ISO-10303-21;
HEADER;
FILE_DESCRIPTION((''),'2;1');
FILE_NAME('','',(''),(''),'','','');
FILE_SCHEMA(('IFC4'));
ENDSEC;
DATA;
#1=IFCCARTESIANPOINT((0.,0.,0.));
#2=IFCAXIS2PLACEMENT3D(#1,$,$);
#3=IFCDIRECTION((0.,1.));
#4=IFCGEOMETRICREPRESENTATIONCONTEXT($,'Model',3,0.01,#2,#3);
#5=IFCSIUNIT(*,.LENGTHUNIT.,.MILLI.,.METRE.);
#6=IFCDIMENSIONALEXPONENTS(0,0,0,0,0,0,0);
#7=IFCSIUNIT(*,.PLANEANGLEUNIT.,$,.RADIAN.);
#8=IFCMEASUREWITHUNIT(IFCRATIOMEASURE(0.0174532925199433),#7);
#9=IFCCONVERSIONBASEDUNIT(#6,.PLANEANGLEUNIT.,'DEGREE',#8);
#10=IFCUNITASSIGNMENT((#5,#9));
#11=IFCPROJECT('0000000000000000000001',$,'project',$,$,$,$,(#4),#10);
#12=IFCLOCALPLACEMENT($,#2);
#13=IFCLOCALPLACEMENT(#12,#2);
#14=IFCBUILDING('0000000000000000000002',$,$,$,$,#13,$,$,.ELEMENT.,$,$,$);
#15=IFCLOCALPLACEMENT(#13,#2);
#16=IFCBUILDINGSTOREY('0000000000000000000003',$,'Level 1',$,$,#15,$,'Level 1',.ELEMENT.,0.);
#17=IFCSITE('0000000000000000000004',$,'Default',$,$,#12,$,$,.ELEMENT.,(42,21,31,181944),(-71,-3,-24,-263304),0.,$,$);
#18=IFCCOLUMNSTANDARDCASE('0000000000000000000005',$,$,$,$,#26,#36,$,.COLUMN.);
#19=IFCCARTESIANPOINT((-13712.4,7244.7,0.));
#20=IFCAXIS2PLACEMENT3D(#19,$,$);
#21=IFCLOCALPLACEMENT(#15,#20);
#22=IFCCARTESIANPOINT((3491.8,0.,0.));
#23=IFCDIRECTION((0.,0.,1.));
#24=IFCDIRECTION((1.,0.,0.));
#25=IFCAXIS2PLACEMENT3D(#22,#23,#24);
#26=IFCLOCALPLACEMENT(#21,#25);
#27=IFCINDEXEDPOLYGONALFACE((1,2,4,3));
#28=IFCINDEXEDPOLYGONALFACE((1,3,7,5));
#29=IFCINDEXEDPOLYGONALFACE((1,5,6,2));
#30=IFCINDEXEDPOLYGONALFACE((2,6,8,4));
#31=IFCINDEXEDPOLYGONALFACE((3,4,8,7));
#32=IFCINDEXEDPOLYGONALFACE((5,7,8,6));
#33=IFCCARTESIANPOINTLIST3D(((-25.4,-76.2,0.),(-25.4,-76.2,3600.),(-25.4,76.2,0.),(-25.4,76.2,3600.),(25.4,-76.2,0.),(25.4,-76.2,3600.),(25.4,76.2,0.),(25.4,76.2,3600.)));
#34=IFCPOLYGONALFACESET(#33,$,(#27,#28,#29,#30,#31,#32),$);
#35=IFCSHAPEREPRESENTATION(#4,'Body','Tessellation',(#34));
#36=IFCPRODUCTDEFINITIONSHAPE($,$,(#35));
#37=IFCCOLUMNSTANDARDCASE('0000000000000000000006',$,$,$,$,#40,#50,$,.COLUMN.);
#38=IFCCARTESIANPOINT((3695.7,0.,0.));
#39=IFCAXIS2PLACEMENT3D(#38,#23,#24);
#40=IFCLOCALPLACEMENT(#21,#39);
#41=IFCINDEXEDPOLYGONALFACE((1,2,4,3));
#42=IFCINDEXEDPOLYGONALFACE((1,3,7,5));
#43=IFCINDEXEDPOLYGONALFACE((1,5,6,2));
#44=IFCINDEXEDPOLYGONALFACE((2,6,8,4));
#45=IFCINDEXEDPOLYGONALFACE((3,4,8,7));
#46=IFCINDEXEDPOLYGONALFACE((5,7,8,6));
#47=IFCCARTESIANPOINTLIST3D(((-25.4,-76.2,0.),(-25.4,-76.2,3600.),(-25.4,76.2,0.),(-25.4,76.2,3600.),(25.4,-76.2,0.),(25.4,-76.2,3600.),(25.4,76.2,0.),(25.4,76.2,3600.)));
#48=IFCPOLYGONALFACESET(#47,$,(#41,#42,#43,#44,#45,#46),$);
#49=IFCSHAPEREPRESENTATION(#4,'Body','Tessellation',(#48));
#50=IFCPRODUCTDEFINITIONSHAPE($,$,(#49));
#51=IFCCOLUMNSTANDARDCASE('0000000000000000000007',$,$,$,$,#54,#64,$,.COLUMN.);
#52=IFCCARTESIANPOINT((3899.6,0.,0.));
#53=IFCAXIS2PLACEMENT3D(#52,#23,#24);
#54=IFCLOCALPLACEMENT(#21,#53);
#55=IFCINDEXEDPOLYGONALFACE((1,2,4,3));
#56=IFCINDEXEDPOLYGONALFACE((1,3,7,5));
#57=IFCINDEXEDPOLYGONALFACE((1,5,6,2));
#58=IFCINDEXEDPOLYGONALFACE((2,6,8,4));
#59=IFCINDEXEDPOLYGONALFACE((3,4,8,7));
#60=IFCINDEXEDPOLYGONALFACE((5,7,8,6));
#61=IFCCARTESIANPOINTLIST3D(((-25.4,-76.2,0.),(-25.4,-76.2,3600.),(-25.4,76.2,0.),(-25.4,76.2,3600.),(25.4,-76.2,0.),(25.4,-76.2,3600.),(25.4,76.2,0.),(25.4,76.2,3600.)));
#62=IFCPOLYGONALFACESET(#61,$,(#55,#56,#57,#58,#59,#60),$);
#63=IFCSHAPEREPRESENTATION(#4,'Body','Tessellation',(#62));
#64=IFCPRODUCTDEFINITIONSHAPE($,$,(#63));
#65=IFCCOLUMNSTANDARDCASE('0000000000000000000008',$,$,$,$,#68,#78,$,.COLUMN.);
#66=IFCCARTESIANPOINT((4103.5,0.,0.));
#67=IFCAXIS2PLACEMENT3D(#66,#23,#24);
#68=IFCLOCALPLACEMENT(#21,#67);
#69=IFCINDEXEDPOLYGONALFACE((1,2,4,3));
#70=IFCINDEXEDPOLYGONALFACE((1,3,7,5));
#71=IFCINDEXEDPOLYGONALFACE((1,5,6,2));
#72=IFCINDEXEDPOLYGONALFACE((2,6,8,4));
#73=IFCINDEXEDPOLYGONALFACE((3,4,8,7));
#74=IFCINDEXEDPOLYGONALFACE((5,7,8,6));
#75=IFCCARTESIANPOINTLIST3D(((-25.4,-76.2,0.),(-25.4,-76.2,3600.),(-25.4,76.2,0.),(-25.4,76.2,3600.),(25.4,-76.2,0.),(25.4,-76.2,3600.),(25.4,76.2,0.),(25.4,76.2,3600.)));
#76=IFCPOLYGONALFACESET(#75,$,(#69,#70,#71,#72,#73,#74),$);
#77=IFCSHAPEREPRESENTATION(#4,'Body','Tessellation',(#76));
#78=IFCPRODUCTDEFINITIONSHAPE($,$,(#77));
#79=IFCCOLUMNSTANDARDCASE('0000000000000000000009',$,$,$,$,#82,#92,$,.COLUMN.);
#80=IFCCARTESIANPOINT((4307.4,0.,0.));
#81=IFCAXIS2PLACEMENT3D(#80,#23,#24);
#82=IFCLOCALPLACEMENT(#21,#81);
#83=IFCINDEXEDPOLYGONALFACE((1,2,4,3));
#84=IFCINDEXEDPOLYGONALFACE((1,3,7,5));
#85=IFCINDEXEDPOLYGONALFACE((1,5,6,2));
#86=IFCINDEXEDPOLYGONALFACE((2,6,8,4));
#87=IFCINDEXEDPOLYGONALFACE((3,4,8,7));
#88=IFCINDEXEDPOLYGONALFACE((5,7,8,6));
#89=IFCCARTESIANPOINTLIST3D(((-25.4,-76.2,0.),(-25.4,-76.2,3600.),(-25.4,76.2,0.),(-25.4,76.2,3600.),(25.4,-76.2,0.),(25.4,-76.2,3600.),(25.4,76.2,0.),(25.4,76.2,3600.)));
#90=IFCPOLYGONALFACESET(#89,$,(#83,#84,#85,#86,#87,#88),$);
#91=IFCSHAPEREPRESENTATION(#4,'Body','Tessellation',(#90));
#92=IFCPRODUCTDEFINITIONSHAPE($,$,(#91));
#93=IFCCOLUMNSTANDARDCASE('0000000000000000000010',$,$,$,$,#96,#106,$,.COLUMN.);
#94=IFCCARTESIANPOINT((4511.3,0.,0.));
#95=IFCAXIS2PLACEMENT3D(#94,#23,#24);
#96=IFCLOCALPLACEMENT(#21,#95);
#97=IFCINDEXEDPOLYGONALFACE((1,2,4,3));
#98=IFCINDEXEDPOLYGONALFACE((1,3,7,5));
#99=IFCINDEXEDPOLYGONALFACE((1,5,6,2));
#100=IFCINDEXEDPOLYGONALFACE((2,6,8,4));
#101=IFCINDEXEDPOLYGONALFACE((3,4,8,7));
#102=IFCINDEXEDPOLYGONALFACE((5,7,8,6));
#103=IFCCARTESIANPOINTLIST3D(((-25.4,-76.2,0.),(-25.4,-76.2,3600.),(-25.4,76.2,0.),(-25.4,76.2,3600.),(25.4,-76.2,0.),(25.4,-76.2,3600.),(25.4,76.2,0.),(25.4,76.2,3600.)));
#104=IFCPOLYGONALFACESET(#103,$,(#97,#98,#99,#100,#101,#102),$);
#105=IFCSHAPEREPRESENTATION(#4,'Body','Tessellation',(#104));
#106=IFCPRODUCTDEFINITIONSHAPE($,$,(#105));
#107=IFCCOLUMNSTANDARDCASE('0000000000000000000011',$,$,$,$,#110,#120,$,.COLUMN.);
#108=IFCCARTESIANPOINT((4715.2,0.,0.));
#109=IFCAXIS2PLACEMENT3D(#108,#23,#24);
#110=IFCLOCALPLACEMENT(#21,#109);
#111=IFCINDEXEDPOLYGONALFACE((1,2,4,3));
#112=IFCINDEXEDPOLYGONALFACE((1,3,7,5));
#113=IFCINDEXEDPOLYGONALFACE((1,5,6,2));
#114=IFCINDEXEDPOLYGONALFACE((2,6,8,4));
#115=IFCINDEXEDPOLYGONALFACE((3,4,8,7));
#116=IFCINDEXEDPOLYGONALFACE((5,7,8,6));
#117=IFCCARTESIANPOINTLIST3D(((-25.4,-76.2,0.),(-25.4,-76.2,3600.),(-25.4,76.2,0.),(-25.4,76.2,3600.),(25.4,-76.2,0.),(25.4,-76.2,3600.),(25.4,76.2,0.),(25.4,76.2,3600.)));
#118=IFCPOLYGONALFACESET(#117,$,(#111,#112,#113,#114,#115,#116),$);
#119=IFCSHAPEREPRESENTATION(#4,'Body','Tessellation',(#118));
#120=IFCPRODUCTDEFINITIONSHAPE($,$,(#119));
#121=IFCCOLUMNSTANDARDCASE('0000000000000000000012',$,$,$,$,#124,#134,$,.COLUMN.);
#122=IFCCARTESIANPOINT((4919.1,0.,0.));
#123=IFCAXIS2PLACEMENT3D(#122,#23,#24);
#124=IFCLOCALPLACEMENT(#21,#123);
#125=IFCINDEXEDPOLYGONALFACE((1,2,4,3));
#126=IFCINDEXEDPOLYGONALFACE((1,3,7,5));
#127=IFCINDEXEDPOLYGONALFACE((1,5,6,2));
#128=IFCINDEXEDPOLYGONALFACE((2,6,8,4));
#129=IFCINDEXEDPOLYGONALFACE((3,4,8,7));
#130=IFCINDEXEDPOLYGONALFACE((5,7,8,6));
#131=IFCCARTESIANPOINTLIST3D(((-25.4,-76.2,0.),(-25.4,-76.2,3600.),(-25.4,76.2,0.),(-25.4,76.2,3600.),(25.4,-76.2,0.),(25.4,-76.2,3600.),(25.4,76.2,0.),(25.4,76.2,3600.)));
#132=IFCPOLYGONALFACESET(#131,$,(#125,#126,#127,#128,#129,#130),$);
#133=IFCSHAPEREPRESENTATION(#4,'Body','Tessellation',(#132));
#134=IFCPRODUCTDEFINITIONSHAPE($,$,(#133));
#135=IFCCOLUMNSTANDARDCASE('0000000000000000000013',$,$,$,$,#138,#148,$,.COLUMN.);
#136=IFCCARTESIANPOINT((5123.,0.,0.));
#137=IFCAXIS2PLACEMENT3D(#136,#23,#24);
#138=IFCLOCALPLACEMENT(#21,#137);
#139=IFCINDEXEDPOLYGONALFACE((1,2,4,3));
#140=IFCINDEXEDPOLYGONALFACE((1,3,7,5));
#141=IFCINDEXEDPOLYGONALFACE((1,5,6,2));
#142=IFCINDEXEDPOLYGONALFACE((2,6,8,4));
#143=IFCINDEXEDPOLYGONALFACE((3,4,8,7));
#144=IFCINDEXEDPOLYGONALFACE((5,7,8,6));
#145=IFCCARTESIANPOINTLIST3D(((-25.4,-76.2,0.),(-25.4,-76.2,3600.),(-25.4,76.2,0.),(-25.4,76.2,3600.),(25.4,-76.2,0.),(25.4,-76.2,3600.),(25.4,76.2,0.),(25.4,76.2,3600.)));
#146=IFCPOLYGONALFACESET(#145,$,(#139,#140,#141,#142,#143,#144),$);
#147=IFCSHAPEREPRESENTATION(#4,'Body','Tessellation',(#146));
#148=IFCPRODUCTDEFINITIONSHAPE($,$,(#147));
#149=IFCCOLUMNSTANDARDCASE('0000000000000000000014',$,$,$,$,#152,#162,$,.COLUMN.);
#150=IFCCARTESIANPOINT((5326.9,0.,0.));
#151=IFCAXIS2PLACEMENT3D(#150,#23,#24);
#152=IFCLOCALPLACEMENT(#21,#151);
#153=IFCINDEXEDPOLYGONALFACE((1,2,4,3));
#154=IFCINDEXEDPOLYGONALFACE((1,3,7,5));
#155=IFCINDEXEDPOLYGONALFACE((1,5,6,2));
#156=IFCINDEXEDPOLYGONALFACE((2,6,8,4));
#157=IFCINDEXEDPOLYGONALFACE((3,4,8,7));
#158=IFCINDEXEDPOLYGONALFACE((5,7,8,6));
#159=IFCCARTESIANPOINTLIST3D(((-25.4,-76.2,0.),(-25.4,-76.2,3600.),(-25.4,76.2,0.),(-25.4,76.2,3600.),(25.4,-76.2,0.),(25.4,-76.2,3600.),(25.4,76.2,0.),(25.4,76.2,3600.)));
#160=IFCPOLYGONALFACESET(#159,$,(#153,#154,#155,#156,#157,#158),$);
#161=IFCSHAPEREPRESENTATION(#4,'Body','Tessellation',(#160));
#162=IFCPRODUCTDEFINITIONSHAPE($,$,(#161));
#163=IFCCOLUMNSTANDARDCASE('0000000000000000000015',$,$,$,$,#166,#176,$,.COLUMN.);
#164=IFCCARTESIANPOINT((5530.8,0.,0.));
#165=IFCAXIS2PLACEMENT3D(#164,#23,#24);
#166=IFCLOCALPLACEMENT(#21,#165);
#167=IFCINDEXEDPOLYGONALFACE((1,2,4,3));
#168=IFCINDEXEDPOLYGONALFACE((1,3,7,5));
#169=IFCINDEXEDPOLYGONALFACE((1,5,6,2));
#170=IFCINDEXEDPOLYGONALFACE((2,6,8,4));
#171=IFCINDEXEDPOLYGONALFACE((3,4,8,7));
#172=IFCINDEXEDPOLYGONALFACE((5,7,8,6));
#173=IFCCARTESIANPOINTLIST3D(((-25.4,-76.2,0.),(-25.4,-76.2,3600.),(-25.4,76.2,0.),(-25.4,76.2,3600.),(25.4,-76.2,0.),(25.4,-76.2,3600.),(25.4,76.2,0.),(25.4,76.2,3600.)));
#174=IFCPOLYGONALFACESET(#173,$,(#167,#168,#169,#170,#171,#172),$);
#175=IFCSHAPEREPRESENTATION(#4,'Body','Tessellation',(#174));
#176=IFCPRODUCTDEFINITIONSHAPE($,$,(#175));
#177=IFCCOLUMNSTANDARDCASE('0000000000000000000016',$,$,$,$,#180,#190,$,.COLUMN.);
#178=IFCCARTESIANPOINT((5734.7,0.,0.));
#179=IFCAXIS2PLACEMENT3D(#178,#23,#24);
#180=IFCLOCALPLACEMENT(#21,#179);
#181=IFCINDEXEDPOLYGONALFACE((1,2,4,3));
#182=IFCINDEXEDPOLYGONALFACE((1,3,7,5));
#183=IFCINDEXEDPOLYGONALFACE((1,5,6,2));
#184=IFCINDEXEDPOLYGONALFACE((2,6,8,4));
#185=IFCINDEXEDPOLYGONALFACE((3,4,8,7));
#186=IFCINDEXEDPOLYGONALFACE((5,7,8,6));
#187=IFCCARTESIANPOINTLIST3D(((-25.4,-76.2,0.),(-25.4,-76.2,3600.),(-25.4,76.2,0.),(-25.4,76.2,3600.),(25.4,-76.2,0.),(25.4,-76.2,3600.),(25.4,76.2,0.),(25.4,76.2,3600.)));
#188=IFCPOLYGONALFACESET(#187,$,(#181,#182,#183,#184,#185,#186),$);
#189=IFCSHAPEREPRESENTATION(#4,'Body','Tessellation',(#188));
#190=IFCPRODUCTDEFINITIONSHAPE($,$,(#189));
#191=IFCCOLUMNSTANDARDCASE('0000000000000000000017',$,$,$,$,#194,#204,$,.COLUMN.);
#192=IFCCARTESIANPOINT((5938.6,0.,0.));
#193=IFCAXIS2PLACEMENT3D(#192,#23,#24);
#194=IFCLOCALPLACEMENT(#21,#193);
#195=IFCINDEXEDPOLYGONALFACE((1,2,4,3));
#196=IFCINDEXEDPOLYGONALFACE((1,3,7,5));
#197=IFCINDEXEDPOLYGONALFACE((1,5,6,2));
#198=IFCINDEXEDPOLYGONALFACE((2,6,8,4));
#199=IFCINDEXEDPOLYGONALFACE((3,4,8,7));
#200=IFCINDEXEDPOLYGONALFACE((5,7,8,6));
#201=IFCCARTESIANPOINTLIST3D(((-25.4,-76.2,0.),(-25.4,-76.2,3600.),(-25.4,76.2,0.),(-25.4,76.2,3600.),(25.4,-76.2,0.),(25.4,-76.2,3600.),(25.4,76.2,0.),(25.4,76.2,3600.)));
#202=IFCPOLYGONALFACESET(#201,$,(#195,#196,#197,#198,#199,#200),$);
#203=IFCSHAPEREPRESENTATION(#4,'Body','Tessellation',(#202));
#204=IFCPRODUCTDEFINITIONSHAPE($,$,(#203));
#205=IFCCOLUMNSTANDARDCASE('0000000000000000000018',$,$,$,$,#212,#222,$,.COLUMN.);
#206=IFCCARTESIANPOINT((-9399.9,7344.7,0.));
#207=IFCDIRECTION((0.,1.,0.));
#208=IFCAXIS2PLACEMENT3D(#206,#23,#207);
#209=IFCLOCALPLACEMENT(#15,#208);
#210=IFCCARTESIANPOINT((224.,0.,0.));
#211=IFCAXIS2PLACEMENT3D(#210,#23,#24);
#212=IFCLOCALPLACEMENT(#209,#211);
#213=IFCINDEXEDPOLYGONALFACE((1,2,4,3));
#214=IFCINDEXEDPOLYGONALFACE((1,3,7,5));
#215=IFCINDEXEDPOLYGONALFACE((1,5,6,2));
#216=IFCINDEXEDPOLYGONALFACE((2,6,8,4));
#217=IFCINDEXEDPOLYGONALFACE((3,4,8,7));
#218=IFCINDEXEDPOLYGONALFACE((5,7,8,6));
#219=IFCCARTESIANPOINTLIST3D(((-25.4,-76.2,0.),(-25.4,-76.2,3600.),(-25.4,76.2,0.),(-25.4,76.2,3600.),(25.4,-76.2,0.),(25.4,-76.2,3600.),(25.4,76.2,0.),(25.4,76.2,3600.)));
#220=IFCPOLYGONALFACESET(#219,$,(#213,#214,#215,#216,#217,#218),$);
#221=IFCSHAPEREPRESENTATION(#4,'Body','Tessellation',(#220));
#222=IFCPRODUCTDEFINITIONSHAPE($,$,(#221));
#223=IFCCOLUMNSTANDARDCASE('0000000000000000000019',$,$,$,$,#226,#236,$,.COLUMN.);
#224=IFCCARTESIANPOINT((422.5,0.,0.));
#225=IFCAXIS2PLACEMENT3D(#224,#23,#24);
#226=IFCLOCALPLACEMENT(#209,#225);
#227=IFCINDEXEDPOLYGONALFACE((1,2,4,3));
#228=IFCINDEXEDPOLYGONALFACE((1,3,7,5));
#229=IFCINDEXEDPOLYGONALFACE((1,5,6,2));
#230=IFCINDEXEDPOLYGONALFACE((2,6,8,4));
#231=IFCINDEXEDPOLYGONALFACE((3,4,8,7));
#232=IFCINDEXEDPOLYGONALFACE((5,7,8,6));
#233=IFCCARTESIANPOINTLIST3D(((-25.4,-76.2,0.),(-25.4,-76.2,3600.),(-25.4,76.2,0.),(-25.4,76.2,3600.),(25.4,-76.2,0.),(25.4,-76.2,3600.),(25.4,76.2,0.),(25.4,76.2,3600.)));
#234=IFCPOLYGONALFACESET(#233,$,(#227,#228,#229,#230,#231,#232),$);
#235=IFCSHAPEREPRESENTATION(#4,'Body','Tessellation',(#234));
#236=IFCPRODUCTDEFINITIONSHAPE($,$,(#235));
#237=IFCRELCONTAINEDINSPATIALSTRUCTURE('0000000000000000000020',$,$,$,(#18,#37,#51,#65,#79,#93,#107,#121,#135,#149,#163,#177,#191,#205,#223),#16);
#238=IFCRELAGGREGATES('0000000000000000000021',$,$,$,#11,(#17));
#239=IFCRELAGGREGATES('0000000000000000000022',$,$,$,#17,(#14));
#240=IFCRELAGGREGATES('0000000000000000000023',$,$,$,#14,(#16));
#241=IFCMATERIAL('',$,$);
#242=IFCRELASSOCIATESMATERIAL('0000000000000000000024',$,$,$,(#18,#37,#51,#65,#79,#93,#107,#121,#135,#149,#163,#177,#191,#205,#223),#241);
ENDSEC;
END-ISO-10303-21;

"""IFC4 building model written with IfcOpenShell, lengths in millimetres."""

from ifc_helpers import new_model, entity, si_unit, converted_unit, direction, frame, origin, place, context, project, spatial, rectangle, extrude, material, element, save


model = new_model("IFC4")

# Units and contexts
model_context = context("Model", 3, precision=0.01, world=origin(), true_north=direction((0.0, 1.0)))
ifc_project = project(units=[si_unit("LENGTHUNIT", "METRE", prefix="MILLI"), converted_unit("PLANEANGLEUNIT", "DEGREE", entity("IfcRatioMeasure", 0.0174532925199433), si_unit("PLANEANGLEUNIT", "RADIAN"), dimensions=[0, 0, 0, 0, 0, 0, 0])], contexts=[model_context])

# Site, building, storey
site_placement = place(None, origin())
site = spatial("IfcSite", under=ifc_project, at=site_placement, Name="Default", CompositionType="ELEMENT", RefLatitude=(42, 21, 31, 181944), RefLongitude=(-71, -3, -24, -263304), RefElevation=0.0)
building_placement = place(site_placement, origin())
building = spatial("IfcBuilding", under=site, at=building_placement, CompositionType="ELEMENT")
storey_placement = place(building_placement, origin())
storey = spatial("IfcBuildingStorey", under=building, at=storey_placement, Name="Level 1", LongName="Level 1", CompositionType="ELEMENT", Elevation=0.0)

# Columns
ifc_material_1 = material(Name="")
placement_1 = place(storey_placement, frame((-13712.4, 7244.7, 0.0)))
for number, where, z_axis, x_axis in (
    (1, (3491.8, 0.0, 0.0), (0.0, 0.0, 1.0), (1.0, 0.0, 0.0)),
    (2, (3695.7, 0.0, 0.0), (0.0, 0.0, 1.0), (1.0, 0.0, 0.0)),
    (3, (3899.6, 0.0, 0.0), (0.0, 0.0, 1.0), (1.0, 0.0, 0.0)),
    (4, (4103.5, 0.0, 0.0), (0.0, 0.0, 1.0), (1.0, 0.0, 0.0)),
    (5, (4307.4, 0.0, 0.0), (0.0, 0.0, 1.0), (1.0, 0.0, 0.0)),
    (6, (4511.3, 0.0, 0.0), (0.0, 0.0, 1.0), (1.0, 0.0, 0.0)),
    (7, (4715.2, 0.0, 0.0), (0.0, 0.0, 1.0), (1.0, 0.0, 0.0)),
    (8, (4919.1, 0.0, 0.0), (0.0, 0.0, 1.0), (1.0, 0.0, 0.0)),
    (9, (5123.0, 0.0, 0.0), (0.0, 0.0, 1.0), (1.0, 0.0, 0.0)),
    (10, (5326.9, 0.0, 0.0), (0.0, 0.0, 1.0), (1.0, 0.0, 0.0)),
    (11, (5530.8, 0.0, 0.0), (0.0, 0.0, 1.0), (1.0, 0.0, 0.0)),
    (12, (5734.7, 0.0, 0.0), (0.0, 0.0, 1.0), (1.0, 0.0, 0.0)),
    (13, (5938.6, 0.0, 0.0), (0.0, 0.0, 1.0), (1.0, 0.0, 0.0)),
):
    element("IfcColumnStandardCase", number, at=place(placement_1, frame(where, z_axis=z_axis, x_axis=x_axis)), inside=storey, material=ifc_material_1, PredefinedType="COLUMN", context=model_context, shape_type="SweptSolid", body=[
        extrude(rectangle(XDim=50.8, YDim=152.4), origin(), (0.0, 0.0, 1.0), 3600.0),
    ])
placement_2 = place(storey_placement, frame((-9399.9, 7344.7, 0.0), z_axis=(0.0, 0.0, 1.0), x_axis=(0.0, 1.0, 0.0)))
for number, where, z_axis, x_axis in (
    (14, (224.0, 0.0, 0.0), (0.0, 0.0, 1.0), (1.0, 0.0, 0.0)),
    (15, (422.5, 0.0, 0.0), (0.0, 0.0, 1.0), (1.0, 0.0, 0.0)),
):
    element("IfcColumnStandardCase", number, at=place(placement_2, frame(where, z_axis=z_axis, x_axis=x_axis)), inside=storey, material=ifc_material_1, PredefinedType="COLUMN", context=model_context, shape_type="SweptSolid", body=[
        extrude(rectangle(XDim=50.8, YDim=152.4), origin(), (0.0, 0.0, 1.0), 3600.0),
    ])

save(model, "model.ifc")
